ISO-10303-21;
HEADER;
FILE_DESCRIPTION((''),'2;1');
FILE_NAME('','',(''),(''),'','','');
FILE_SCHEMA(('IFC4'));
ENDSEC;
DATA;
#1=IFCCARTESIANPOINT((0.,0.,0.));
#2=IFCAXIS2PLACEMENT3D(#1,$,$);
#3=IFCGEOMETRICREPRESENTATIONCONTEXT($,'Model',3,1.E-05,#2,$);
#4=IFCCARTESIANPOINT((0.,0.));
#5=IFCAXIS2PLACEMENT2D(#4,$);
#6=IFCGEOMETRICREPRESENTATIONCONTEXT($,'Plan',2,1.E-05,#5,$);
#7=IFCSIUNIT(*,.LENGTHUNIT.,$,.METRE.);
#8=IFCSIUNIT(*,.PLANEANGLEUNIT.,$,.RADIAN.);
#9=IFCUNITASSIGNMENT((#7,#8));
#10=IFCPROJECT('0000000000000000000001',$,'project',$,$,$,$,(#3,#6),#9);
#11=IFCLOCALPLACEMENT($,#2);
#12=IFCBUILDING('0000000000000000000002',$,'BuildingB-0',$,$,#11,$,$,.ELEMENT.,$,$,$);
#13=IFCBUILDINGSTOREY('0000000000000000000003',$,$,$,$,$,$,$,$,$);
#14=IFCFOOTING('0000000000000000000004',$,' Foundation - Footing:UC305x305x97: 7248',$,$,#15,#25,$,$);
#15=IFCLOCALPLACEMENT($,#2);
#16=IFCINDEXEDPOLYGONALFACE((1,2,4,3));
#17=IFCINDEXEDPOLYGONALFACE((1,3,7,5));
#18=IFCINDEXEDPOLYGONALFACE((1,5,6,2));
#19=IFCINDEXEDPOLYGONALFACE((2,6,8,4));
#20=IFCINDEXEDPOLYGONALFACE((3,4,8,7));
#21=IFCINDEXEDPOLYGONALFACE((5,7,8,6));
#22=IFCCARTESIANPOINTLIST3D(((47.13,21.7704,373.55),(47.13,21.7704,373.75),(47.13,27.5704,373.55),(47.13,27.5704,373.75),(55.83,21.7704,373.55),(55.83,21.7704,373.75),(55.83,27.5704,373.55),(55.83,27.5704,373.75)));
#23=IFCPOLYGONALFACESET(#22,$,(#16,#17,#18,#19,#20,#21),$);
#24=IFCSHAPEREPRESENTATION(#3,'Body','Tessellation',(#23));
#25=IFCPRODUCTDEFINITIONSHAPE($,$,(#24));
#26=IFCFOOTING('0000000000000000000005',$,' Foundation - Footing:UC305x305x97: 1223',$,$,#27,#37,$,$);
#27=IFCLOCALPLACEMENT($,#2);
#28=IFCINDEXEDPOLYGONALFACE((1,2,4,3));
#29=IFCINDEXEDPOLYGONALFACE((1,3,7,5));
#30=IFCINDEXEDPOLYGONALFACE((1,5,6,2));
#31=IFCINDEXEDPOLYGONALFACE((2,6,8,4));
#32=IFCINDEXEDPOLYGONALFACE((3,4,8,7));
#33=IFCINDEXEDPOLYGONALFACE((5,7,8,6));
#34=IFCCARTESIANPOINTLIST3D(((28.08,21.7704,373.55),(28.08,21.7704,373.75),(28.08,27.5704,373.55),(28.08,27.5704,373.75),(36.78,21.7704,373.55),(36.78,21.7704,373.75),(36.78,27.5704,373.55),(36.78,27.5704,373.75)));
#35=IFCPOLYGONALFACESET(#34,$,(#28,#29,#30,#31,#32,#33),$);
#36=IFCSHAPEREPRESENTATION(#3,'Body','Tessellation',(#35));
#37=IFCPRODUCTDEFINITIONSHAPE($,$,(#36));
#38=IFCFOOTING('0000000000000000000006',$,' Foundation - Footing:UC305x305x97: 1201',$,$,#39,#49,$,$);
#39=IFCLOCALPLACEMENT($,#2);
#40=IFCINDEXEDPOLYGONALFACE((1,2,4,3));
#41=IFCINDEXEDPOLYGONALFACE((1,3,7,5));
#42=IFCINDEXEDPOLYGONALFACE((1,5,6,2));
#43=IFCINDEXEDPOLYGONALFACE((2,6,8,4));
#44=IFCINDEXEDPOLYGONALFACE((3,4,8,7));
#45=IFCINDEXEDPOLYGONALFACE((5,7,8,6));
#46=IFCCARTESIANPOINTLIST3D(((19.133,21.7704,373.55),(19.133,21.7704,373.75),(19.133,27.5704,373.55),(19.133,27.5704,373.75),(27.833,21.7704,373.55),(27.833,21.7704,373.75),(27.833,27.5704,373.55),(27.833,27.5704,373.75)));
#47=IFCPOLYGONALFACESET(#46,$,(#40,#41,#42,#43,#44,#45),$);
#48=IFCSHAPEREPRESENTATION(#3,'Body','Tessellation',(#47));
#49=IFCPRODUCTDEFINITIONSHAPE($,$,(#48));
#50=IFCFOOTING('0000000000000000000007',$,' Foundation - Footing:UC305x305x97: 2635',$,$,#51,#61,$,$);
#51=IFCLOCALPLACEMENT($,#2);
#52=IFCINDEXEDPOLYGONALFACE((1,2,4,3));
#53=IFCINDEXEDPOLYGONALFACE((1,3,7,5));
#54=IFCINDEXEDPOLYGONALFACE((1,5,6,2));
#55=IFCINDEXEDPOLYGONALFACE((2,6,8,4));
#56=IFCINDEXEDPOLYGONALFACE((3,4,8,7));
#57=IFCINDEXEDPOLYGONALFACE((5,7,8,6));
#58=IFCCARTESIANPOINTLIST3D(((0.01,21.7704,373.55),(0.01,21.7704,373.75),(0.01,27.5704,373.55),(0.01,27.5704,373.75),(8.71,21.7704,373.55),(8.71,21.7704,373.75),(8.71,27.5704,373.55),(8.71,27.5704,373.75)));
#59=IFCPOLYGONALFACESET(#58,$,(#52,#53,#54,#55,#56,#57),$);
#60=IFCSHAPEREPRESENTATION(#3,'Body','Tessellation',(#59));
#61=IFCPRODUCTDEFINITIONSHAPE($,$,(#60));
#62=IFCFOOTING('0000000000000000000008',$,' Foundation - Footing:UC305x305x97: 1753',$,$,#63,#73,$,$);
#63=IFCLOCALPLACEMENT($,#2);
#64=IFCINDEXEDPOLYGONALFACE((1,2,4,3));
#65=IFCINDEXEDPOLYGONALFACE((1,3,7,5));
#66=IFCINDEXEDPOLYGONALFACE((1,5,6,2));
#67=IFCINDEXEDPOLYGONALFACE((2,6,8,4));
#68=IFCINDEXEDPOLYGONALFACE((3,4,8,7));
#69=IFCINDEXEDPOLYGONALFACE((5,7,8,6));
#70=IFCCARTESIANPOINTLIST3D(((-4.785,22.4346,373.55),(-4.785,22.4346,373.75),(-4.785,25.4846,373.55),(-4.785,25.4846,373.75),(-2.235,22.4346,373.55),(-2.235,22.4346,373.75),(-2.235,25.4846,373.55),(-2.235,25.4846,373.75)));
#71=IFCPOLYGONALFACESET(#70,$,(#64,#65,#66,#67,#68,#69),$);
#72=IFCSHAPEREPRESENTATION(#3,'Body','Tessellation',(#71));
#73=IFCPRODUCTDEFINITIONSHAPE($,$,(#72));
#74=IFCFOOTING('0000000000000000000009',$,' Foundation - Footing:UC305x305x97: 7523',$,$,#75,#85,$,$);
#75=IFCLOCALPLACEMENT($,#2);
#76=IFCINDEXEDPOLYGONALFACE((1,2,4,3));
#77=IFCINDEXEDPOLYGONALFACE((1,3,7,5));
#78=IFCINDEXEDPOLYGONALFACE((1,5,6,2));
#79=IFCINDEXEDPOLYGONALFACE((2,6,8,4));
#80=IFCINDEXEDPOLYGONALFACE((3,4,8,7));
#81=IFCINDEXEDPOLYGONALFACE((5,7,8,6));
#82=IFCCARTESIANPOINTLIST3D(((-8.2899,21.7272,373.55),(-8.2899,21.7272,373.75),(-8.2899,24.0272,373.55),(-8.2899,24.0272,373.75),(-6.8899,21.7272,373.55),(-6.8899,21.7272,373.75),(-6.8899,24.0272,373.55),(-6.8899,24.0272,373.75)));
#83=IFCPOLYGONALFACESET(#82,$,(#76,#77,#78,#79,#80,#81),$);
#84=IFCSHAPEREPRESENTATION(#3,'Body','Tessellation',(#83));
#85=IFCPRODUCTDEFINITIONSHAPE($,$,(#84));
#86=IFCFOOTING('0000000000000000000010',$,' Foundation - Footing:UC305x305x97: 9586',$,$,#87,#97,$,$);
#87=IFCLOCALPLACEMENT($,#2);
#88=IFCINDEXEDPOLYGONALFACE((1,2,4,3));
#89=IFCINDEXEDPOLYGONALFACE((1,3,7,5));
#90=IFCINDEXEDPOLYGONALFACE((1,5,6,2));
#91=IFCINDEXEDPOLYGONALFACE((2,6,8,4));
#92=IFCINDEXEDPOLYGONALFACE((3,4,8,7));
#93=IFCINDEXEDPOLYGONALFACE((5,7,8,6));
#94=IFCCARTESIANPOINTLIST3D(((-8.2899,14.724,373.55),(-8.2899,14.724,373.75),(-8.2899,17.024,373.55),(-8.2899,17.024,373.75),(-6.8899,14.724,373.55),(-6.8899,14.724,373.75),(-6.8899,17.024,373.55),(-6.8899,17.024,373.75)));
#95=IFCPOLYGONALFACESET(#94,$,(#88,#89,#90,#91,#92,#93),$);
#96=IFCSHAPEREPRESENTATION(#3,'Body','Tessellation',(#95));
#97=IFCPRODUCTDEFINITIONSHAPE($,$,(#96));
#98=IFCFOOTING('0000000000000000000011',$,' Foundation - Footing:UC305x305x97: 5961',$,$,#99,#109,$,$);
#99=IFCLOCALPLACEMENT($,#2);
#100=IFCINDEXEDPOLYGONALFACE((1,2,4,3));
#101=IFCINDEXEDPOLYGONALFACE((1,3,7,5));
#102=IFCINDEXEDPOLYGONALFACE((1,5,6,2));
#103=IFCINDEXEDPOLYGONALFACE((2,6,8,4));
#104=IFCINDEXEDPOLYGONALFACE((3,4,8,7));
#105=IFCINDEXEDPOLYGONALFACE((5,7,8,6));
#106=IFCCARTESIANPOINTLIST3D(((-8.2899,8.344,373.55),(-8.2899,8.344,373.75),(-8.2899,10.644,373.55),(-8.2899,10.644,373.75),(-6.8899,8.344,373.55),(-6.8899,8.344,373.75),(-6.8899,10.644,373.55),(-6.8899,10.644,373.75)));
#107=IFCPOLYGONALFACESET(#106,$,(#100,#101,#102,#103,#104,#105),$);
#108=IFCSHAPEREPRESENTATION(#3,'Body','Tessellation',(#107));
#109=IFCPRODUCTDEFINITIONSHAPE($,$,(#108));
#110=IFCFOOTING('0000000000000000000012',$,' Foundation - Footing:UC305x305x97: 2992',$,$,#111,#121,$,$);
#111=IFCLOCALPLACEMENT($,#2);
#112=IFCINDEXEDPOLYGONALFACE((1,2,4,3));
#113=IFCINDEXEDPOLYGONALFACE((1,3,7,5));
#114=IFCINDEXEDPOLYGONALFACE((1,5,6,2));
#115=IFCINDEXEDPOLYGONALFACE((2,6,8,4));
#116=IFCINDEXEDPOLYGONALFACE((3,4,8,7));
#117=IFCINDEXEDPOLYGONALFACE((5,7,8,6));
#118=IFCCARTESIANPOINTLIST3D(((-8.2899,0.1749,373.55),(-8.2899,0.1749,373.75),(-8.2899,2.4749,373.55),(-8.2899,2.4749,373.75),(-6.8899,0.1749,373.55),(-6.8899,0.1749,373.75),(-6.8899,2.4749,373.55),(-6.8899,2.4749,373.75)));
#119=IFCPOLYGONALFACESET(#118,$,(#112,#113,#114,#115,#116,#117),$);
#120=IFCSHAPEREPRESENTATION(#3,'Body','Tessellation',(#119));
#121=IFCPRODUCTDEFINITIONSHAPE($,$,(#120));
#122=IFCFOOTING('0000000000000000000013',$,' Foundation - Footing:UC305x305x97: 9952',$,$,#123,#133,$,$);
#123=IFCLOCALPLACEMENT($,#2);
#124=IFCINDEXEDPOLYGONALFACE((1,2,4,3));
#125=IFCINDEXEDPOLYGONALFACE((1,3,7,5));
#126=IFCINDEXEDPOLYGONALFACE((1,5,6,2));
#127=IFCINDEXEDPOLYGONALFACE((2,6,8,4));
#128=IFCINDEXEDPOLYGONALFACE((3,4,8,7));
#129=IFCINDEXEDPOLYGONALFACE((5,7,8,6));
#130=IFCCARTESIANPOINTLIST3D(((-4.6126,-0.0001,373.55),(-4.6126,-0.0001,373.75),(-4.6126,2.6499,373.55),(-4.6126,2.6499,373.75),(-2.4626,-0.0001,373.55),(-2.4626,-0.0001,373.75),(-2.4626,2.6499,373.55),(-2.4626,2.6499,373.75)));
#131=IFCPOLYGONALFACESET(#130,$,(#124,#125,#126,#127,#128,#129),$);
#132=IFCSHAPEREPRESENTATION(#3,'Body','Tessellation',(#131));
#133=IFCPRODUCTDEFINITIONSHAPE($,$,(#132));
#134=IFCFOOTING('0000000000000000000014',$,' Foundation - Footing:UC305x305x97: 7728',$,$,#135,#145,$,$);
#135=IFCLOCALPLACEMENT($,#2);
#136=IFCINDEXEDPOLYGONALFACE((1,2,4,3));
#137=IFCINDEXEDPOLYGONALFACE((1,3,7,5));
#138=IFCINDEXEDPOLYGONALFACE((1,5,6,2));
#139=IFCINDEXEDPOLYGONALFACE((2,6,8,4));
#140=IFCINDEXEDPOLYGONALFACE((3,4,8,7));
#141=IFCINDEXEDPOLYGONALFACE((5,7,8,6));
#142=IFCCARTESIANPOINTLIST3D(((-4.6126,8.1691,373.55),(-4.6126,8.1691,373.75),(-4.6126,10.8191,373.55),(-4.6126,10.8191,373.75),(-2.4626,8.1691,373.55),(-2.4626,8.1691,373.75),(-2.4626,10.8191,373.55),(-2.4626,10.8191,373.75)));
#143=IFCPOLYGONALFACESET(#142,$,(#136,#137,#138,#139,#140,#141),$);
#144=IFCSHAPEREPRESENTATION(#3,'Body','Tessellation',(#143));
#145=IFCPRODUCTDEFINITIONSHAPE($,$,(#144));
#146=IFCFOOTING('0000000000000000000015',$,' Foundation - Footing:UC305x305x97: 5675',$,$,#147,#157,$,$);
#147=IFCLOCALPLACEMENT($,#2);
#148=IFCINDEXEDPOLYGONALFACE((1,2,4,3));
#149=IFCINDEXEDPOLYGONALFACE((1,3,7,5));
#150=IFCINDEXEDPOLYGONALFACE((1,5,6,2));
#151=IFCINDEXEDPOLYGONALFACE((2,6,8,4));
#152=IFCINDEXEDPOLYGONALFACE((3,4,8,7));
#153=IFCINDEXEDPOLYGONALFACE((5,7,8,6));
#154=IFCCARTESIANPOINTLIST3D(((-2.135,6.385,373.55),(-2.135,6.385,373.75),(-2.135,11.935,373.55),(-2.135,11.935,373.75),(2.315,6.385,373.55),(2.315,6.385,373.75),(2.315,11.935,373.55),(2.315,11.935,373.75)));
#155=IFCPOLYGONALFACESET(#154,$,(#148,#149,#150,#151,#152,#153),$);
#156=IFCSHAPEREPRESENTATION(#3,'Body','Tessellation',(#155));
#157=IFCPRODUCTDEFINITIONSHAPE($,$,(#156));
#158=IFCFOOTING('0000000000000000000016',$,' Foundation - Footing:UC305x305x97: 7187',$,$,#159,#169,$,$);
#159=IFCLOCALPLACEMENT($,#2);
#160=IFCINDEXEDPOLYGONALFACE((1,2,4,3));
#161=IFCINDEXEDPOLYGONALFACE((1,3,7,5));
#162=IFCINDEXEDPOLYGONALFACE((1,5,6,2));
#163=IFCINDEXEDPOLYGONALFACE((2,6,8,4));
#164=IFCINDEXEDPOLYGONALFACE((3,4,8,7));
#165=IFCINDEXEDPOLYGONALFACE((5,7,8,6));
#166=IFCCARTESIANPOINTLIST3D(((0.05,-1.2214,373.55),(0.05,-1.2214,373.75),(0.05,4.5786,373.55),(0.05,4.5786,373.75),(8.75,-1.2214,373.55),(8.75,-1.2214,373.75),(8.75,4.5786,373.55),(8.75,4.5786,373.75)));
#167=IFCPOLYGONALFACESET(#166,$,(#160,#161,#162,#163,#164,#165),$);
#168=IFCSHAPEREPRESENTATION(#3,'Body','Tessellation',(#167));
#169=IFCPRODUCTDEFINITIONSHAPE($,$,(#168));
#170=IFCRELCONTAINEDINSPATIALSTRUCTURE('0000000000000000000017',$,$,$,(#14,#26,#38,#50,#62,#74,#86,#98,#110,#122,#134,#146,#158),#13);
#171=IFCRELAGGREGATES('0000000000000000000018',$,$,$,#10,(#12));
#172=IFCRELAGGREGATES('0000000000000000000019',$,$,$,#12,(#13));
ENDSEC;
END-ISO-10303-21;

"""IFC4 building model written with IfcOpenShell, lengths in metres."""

from ifc_helpers import new_model, si_unit, origin, origin_2d, place, context, project, spatial, polyline, outline, extrude, element, save


model = new_model("IFC4")

# Units and contexts
model_context = context("Model", 3, precision=1e-05, world=origin())
plan_context = context("Plan", 2, precision=1e-05, world=origin_2d())
ifc_project = project(units=[si_unit("LENGTHUNIT", "METRE"), si_unit("PLANEANGLEUNIT", "RADIAN")], contexts=[model_context, plan_context])

# Building, storey
building_placement = place(None, origin())
building = spatial("IfcBuilding", under=ifc_project, at=building_placement, Name="BuildingB-0", CompositionType="ELEMENT")
storey = spatial("IfcBuildingStorey", under=building)

# Footings
element("IfcFooting", 1, inside=storey, Name=" Foundation - Footing:UC305x305x97: 7248", context=model_context, shape_type="SweptSolid", body=[
    extrude(outline(polyline([(47.13, 21.7704, 373.55), (55.83, 21.7704, 373.55), (55.83, 27.5704, 373.55), (47.13, 27.5704, 373.55), (47.13, 21.7704, 373.55)])), None, (0.0, 0.0, 1.0), 0.2),
])
element("IfcFooting", 2, inside=storey, Name=" Foundation - Footing:UC305x305x97: 1223", context=model_context, shape_type="SweptSolid", body=[
    extrude(outline(polyline([(28.08, 21.7704, 373.55), (36.78, 21.7704, 373.55), (36.78, 27.5704, 373.55), (28.08, 27.5704, 373.55), (28.08, 21.7704, 373.55)])), None, (0.0, 0.0, 1.0), 0.2),
])
element("IfcFooting", 3, inside=storey, Name=" Foundation - Footing:UC305x305x97: 1201", context=model_context, shape_type="SweptSolid", body=[
    extrude(outline(polyline([(27.833, 27.5704, 373.55), (19.133, 27.5704, 373.55), (19.133, 21.7704, 373.55), (27.833, 21.7704, 373.55), (27.833, 27.5704, 373.55)])), None, (0.0, 0.0, 1.0), 0.2),
])
element("IfcFooting", 4, inside=storey, Name=" Foundation - Footing:UC305x305x97: 2635", context=model_context, shape_type="SweptSolid", body=[
    extrude(outline(polyline([(8.71, 27.5704, 373.55), (0.01, 27.5704, 373.55), (0.01, 21.7704, 373.55), (8.71, 21.7704, 373.55), (8.71, 27.5704, 373.55)])), None, (0.0, 0.0, 1.0), 0.2),
])
element("IfcFooting", 5, inside=storey, Name=" Foundation - Footing:UC305x305x97: 1753", context=model_context, shape_type="SweptSolid", body=[
    extrude(outline(polyline([(-2.235, 25.4846, 373.55), (-4.785, 25.4846, 373.55), (-4.785, 22.4346, 373.55), (-2.235, 22.4346, 373.55), (-2.235, 25.4846, 373.55)])), None, (0.0, 0.0, 1.0), 0.2),
])
element("IfcFooting", 6, inside=storey, Name=" Foundation - Footing:UC305x305x97: 7523", context=model_context, shape_type="SweptSolid", body=[
    extrude(outline(polyline([(-6.8899, 24.0272, 373.55), (-8.2899, 24.0272, 373.55), (-8.2899, 21.7272, 373.55), (-6.8899, 21.7272, 373.55), (-6.8899, 24.0272, 373.55)])), None, (0.0, 0.0, 1.0), 0.2),
])
element("IfcFooting", 7, inside=storey, Name=" Foundation - Footing:UC305x305x97: 9586", context=model_context, shape_type="SweptSolid", body=[
    extrude(outline(polyline([(-8.2899, 14.724, 373.55), (-6.8899, 14.724, 373.55), (-6.8899, 17.024, 373.55), (-8.2899, 17.024, 373.55), (-8.2899, 14.724, 373.55)])), None, (0.0, 0.0, 1.0), 0.2),
])
element("IfcFooting", 8, inside=storey, Name=" Foundation - Footing:UC305x305x97: 5961", context=model_context, shape_type="SweptSolid", body=[
    extrude(outline(polyline([(-8.2899, 8.344, 373.55), (-6.8899, 8.344, 373.55), (-6.8899, 10.644, 373.55), (-8.2899, 10.644, 373.55), (-8.2899, 8.344, 373.55)])), None, (0.0, 0.0, 1.0), 0.2),
])
element("IfcFooting", 9, inside=storey, Name=" Foundation - Footing:UC305x305x97: 2992", context=model_context, shape_type="SweptSolid", body=[
    extrude(outline(polyline([(-8.2899, 0.1749, 373.55), (-6.8899, 0.1749, 373.55), (-6.8899, 2.4749, 373.55), (-8.2899, 2.4749, 373.55), (-8.2899, 0.1749, 373.55)])), None, (0.0, 0.0, 1.0), 0.2),
])
element("IfcFooting", 10, inside=storey, Name=" Foundation - Footing:UC305x305x97: 9952", context=model_context, shape_type="SweptSolid", body=[
    extrude(outline(polyline([(-4.6126, -0.0001, 373.55), (-2.4626, -0.0001, 373.55), (-2.4626, 2.6499, 373.55), (-4.6126, 2.6499, 373.55), (-4.6126, -0.0001, 373.55)])), None, (0.0, 0.0, 1.0), 0.2),
])
element("IfcFooting", 11, inside=storey, Name=" Foundation - Footing:UC305x305x97: 7728", context=model_context, shape_type="SweptSolid", body=[
    extrude(outline(polyline([(-4.6126, 8.1691, 373.55), (-2.4626, 8.1691, 373.55), (-2.4626, 10.8191, 373.55), (-4.6126, 10.8191, 373.55), (-4.6126, 8.1691, 373.55)])), None, (0.0, 0.0, 1.0), 0.2),
])
element("IfcFooting", 12, inside=storey, Name=" Foundation - Footing:UC305x305x97: 5675", context=model_context, shape_type="SweptSolid", body=[
    extrude(outline(polyline([(-2.135, 6.385, 373.55), (2.315, 6.385, 373.55), (2.315, 11.935, 373.55), (-2.135, 11.935, 373.55), (-2.135, 6.385, 373.55)])), None, (0.0, 0.0, 1.0), 0.2),
])
element("IfcFooting", 13, inside=storey, Name=" Foundation - Footing:UC305x305x97: 7187", context=model_context, shape_type="SweptSolid", body=[
    extrude(outline(polyline([(0.05, -1.2214, 373.55), (8.75, -1.2214, 373.55), (8.75, 4.5786, 373.55), (0.05, 4.5786, 373.55), (0.05, -1.2214, 373.55)])), None, (0.0, 0.0, 1.0), 0.2),
])

save(model, "model.ifc")
